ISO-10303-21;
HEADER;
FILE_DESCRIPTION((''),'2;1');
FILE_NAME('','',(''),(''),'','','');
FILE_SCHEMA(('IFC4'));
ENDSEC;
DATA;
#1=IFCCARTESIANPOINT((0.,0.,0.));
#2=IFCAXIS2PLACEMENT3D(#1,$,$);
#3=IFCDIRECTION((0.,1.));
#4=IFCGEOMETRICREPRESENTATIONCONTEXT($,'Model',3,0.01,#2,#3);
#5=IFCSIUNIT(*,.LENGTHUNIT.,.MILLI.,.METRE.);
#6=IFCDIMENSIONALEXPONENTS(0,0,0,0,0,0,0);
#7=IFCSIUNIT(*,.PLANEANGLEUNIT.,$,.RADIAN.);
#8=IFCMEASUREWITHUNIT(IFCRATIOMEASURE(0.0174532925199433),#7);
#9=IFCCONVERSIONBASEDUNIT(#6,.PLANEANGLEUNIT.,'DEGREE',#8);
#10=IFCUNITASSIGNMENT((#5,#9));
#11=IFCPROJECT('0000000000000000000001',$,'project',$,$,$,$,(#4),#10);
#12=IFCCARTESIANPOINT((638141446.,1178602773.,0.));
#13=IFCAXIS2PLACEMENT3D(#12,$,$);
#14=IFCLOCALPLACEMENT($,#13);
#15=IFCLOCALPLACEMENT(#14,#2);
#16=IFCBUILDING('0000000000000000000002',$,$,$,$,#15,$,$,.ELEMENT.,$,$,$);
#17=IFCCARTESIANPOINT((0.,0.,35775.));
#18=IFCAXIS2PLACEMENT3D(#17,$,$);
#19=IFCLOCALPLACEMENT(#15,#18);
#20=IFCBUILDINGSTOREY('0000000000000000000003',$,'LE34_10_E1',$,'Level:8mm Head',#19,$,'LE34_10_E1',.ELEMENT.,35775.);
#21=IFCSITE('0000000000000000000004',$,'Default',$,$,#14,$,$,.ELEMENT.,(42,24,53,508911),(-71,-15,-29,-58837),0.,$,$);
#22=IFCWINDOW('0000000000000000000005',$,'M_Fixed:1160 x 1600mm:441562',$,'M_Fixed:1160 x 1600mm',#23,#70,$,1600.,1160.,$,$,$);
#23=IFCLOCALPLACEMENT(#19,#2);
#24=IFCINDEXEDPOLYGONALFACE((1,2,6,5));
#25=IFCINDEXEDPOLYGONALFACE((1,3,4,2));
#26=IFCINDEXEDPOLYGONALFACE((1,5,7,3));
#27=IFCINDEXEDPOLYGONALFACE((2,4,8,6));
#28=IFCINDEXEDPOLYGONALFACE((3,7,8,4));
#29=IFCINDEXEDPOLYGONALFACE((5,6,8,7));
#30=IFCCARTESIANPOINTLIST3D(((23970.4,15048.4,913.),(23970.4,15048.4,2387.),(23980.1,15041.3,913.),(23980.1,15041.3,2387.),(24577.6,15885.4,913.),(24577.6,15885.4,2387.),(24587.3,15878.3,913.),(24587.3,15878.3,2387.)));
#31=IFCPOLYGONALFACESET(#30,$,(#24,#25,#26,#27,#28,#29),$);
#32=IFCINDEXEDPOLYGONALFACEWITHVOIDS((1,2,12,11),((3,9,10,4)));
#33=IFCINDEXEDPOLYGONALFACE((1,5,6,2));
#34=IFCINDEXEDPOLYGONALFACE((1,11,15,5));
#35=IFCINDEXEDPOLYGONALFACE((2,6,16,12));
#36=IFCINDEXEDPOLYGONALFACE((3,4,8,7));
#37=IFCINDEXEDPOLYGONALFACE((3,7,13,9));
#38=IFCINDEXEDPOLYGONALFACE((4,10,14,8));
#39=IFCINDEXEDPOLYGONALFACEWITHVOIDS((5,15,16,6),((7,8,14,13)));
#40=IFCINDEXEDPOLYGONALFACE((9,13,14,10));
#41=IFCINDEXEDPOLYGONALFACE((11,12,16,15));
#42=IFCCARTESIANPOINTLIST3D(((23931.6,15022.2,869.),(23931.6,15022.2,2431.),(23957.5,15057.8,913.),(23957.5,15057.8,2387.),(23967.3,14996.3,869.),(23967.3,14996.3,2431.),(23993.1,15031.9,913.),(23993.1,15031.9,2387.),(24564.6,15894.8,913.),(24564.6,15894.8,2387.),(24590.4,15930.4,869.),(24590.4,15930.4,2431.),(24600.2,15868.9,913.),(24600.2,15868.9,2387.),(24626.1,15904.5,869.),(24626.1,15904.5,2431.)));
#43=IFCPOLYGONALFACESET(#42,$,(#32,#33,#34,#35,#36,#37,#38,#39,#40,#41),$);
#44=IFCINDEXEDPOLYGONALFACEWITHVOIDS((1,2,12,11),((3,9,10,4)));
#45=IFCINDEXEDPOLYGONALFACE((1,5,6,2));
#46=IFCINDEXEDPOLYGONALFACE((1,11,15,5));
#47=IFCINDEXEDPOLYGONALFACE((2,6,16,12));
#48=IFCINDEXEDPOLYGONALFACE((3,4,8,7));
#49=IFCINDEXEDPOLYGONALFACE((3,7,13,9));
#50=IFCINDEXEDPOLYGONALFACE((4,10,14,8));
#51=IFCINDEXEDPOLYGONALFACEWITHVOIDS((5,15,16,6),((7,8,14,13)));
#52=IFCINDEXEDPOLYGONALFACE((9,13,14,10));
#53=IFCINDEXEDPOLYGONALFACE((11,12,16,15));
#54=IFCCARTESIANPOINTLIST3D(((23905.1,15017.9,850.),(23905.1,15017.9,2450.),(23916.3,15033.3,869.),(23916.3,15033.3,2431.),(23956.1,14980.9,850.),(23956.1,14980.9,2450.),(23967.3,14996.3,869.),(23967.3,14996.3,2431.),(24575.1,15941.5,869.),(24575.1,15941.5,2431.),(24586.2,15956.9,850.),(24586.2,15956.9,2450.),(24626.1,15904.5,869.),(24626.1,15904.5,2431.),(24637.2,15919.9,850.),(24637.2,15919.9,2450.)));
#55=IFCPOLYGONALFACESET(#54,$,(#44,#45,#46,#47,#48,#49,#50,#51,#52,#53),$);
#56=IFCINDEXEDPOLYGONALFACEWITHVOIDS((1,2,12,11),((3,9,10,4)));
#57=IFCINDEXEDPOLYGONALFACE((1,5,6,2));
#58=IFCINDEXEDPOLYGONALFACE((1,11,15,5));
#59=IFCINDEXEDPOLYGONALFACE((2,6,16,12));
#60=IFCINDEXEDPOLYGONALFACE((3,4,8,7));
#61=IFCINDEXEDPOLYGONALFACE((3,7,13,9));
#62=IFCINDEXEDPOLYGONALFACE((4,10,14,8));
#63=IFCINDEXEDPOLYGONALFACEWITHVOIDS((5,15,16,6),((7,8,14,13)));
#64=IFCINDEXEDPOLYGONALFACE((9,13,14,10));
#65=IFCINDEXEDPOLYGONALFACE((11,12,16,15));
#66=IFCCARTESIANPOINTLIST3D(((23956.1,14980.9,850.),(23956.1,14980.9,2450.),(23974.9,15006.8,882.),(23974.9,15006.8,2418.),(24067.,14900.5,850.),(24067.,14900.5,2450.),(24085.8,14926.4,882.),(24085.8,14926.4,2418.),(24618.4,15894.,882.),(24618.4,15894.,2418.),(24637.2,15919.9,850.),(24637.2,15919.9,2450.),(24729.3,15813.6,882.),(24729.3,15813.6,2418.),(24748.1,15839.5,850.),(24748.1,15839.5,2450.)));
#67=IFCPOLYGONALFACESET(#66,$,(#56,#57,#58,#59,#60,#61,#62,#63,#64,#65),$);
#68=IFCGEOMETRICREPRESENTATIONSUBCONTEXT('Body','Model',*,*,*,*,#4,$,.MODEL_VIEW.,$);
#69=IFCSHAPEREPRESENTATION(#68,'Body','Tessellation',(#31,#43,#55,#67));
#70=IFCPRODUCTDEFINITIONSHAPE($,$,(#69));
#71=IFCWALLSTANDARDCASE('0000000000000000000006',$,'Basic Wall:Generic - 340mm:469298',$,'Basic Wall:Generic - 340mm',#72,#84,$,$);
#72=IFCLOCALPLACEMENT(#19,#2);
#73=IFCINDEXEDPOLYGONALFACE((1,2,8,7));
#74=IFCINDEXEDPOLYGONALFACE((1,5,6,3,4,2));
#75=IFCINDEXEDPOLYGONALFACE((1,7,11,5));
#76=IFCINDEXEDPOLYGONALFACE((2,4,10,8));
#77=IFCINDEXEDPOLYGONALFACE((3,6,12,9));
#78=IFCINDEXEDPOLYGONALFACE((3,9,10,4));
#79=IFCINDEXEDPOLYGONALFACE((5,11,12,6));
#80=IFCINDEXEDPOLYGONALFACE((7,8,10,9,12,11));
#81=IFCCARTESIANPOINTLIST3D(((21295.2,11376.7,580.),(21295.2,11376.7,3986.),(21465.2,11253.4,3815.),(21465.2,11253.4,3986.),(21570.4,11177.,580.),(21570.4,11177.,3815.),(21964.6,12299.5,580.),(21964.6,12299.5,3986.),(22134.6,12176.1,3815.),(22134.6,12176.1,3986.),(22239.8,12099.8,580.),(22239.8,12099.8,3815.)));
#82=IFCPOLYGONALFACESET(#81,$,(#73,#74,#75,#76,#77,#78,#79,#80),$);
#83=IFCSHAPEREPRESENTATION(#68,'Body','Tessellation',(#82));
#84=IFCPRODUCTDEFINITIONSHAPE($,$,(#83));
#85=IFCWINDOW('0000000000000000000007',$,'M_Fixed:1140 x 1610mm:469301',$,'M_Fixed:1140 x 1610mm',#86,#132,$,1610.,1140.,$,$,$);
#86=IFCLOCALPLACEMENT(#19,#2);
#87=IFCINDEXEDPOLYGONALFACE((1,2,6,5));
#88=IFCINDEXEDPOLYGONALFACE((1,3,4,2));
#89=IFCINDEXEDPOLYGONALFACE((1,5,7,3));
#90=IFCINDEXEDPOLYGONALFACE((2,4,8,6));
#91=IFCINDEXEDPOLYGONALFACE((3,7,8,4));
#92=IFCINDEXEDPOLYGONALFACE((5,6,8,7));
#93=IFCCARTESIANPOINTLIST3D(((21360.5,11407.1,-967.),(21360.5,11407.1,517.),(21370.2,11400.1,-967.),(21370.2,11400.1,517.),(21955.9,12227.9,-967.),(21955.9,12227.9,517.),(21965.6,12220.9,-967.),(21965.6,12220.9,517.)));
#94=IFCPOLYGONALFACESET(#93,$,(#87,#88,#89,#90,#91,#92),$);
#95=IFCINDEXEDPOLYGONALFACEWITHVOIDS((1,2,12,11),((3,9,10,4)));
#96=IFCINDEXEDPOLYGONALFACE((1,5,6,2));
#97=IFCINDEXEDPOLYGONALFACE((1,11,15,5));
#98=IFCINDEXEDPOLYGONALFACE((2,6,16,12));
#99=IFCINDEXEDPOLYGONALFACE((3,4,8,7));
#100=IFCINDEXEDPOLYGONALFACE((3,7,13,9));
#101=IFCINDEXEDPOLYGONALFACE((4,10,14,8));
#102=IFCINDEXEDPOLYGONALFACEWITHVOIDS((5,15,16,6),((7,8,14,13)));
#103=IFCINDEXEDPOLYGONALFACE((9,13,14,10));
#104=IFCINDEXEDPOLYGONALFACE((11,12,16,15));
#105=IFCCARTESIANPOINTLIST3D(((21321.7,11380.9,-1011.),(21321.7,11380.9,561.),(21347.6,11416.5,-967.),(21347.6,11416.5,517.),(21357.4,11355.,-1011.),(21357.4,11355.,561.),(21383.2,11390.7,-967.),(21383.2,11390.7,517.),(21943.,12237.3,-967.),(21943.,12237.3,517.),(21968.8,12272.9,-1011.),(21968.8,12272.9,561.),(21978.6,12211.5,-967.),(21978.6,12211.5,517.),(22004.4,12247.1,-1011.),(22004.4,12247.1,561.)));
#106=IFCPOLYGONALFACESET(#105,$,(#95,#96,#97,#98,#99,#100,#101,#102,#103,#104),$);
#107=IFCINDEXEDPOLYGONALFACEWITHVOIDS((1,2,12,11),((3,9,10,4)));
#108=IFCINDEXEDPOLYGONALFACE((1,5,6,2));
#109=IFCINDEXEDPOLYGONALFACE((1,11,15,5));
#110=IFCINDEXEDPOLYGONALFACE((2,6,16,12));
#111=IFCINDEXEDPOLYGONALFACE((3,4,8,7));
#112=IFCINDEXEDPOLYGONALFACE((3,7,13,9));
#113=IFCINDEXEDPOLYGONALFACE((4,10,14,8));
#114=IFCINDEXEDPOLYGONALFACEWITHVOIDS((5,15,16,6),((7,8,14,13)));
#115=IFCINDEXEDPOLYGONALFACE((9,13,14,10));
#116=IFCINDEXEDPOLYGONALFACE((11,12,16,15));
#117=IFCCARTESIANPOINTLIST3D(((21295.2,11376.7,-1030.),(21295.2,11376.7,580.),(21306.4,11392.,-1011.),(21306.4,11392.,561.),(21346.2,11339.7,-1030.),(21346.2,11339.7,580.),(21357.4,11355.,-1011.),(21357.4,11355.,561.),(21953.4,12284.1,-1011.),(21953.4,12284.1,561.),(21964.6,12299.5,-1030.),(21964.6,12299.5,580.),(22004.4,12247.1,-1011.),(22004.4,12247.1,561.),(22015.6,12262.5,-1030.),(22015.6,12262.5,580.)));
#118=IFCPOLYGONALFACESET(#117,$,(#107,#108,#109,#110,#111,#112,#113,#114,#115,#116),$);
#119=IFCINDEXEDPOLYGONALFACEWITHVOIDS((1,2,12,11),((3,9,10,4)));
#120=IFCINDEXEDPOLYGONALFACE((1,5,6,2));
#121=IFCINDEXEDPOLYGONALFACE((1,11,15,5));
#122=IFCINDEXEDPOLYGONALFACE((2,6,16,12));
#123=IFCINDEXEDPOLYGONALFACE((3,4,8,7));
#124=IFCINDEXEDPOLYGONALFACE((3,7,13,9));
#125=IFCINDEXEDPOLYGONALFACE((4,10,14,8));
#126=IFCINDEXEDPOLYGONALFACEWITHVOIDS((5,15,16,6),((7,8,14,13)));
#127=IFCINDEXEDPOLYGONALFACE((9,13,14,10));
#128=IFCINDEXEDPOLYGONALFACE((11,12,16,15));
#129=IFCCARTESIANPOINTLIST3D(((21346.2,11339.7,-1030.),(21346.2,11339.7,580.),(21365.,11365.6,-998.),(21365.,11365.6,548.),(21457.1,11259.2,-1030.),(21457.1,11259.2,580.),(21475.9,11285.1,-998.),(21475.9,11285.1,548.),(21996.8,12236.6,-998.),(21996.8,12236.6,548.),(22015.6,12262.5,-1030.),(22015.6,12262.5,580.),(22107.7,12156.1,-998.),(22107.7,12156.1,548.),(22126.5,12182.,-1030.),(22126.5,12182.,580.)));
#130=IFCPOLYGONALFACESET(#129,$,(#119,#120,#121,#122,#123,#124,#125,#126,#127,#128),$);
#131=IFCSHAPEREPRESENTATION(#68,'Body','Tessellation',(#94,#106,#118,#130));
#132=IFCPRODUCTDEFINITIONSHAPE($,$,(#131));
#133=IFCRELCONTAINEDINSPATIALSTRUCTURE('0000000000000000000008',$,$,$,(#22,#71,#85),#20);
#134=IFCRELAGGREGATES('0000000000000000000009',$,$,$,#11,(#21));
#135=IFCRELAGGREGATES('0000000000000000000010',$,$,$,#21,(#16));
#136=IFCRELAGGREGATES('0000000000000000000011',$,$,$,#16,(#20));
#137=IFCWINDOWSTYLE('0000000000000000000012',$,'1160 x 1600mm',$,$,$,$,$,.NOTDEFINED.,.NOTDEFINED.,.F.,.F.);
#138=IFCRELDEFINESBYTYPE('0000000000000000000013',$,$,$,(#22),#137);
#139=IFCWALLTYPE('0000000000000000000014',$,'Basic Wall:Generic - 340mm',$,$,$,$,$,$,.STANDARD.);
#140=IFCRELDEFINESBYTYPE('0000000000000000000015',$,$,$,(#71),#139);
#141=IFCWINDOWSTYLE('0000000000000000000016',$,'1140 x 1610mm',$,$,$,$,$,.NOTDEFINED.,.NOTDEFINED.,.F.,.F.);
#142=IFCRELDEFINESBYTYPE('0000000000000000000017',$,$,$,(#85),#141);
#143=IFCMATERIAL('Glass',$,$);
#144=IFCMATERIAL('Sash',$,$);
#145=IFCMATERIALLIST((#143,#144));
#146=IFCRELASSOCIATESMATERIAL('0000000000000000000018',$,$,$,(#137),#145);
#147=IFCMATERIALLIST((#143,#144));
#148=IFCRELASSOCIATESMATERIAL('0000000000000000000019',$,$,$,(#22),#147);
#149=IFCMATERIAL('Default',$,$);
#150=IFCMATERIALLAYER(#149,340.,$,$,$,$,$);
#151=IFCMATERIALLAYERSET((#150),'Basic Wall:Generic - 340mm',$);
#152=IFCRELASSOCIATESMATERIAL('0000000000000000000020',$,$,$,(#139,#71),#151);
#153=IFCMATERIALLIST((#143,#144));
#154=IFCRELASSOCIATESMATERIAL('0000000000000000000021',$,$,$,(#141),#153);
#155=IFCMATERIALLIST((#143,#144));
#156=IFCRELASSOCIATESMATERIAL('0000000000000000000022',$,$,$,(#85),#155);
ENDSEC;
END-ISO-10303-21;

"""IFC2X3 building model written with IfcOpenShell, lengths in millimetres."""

from ifc_helpers import new_model, entity, si_unit, converted_unit, direction, frame, frame_2d, origin, place, context, subcontext, project, spatial, polyline, rectangle, outline, extrude, clip, bounded_halfspace, source, transform, mapped, material, material_list, layer, layer_set, layer_usage, type_object, type_shapes, element, fill, save


model = new_model("IFC2X3")

# Units and contexts
model_context = context("Model", 3, precision=0.01, world=origin(), true_north=direction((0.0, 1.0)))
body_context = subcontext(model_context, "Body", "Model", "MODEL_VIEW")
ifc_project = project(units=[si_unit("LENGTHUNIT", "METRE", prefix="MILLI"), converted_unit("PLANEANGLEUNIT", "DEGREE", entity("IfcRatioMeasure", 0.0174532925199433), si_unit("PLANEANGLEUNIT", "RADIAN"), dimensions=[0, 0, 0, 0, 0, 0, 0])], contexts=[model_context])

# Site, building, storey
site_placement = place(None, frame((638141446.0, 1178602773.0, 0.0)))
site = spatial("IfcSite", under=ifc_project, at=site_placement, Name="Default", CompositionType="ELEMENT", RefLatitude=(42, 24, 53, 508911), RefLongitude=(-71, -15, -29, -58837), RefElevation=0.0)
building_placement = place(site_placement, origin())
building = spatial("IfcBuilding", under=site, at=building_placement, CompositionType="ELEMENT")
storey_placement = place(building_placement, frame((0.0, 0.0, 35775.0)))
storey = spatial("IfcBuildingStorey", under=building, at=storey_placement, Name="LE34_10_E1", ObjectType="Level:8mm Head", LongName="LE34_10_E1", CompositionType="ELEMENT", Elevation=35775.0)

# Shared definitions
ifc_material_1 = material(Name="Default")

# Window
ifc_material_2 = material(Name="Glass")
ifc_material_3 = material(Name="Sash")
ifc_material_list_1 = material_list([ifc_material_2, ifc_material_3])
ifc_material_list_2 = material_list([ifc_material_2, ifc_material_3])
window_style_1 = type_object("IfcWindowStyle", Name="1160 x 1600mm", ConstructionType="NOTDEFINED", OperationType="NOTDEFINED", ParameterTakesPrecedence=False, Sizeable=False, material=ifc_material_list_2)
shared_shape_1 = source(origin(), body_context, "Body", "SweptSolid", [
    extrude(rectangle(XDim=12.0, YDim=1034.0, at=frame_2d((0.0, 0.0), x_axis=(1.0, 0.0))), frame((580.0, 269.0, 63.0), z_axis=(0.0, 0.0, 1.0), x_axis=(0.0, -1.0, 0.0)), (0.0, 0.0, 1.0), 1474.0),
    extrude(outline(polyline([(-561.0, -781.0), (561.0, -781.0), (561.0, 781.0), (-561.0, 781.0), (-561.0, -781.0)]), holes=[polyline([(-517.0, -737.0), (-517.0, 737.0), (517.0, 737.0), (517.0, -737.0), (-517.0, -737.0)])]), frame((580.0, 247.0, 800.0), z_axis=(0.0, 1.0, 0.0), x_axis=(1.0, 0.0, 0.0)), (0.0, 0.0, 1.0), 44.0),
    extrude(outline(polyline([(-580.0, -800.0), (580.0, -800.0), (580.0, 800.0), (-580.0, 800.0), (-580.0, -800.0)]), holes=[polyline([(-561.0, -781.0), (-561.0, 781.0), (561.0, 781.0), (561.0, -781.0), (-561.0, -781.0)])]), frame((580.0, 247.0, 800.0), z_axis=(0.0, 1.0, 0.0), x_axis=(1.0, 0.0, 0.0)), (0.0, 0.0, 1.0), 63.0),
    extrude(outline(polyline([(-580.0, -800.0), (580.0, -800.0), (580.0, 800.0), (-580.0, 800.0), (-580.0, -800.0)]), holes=[polyline([(-548.0, -768.0), (-548.0, 768.0), (548.0, 768.0), (548.0, -768.0), (-548.0, -768.0)])]), frame((580.0, 110.0, 800.0), z_axis=(0.0, 1.0, 0.0), x_axis=(1.0, 0.0, 0.0)), (0.0, 0.0, 1.0), 137.0),
])
type_shapes(window_style_1, [shared_shape_1])
window_1_placement = place(storey_placement, frame((24156.0, 14835.9, 850.0), z_axis=(0.0, 0.0, 1.0), x_axis=(0.587164, 0.809468, 0.0)))
element("IfcWindow", 1, at=window_1_placement, inside=storey, type_object=window_style_1, material=ifc_material_list_1, Name="M_Fixed:1160 x 1600mm:441562", ObjectType="M_Fixed:1160 x 1600mm", OverallHeight=1600.0, OverallWidth=1160.0, context=body_context, shape_type="MappedRepresentation", body=[
    mapped(shared_shape_1, transform((0.0, 0.0, 0.0), scale=1.0)),
])

# Wall, opening, window
ifc_layer_1 = layer(ifc_material_1, 340.0)
ifc_layer_set_1 = layer_set([ifc_layer_1], Name="Basic Wall:Generic - 340mm")
ifc_layer_usage_1 = layer_usage(ifc_layer_set_1, "AXIS2", "NEGATIVE", 170.0)
wall_type_1 = type_object("IfcWallType", Name="Basic Wall:Generic - 340mm", PredefinedType="STANDARD", material=ifc_layer_set_1)
wall_1_placement = place(storey_placement, frame((21432.8, 11276.8, 580.0), z_axis=(0.0, 0.0, 1.0), x_axis=(0.587164, 0.809468, 0.0)))
wall_1 = element("IfcWallStandardCase", 2, at=wall_1_placement, inside=storey, type_object=wall_type_1, material=ifc_layer_usage_1, Name="Basic Wall:Generic - 340mm:469298", ObjectType="Basic Wall:Generic - 340mm", context=body_context, shape_type="Clipping", body=[
    clip(clip(extrude(rectangle(XDim=1140.0, YDim=340.0, at=frame_2d((570.0, 0.0), x_axis=(-1.0, 0.0))), origin(), (0.0, 0.0, 1.0), 3406.0), bounded_halfspace(frame((1140.0, -40.0, 3235.0), z_axis=(0.0, 0.0, 1.0), x_axis=(-1.0, 0.0, 0.0)), False, frame((1140.0, -40.0, 3235.0), z_axis=(0.0, 0.0, 1.0), x_axis=(-1.0, 0.0, 0.0)), polyline([(0.0, 0.0), (1140.0, 0.0), (1140.0, 130.0), (0.0, 130.0), (0.0, 0.0)]))), bounded_halfspace(frame((0.0, -40.0, 3235.0), z_axis=(0.0, 1.0, 0.0), x_axis=(-1.0, 0.0, 0.0)), True, frame((0.0, -40.0, 3235.0), z_axis=(0.0, 1.0, 0.0), x_axis=(-1.0, 0.0, 0.0)), polyline([(0.0, 0.0), (0.0, 100.0), (0.0, 171.0), (-1140.0, 171.0), (-1140.0, 0.0), (0.0, 0.0)]))),
])
opening_1_placement = place(wall_1_placement, frame((0.0, -170.0, -1610.0)))
opening_1 = element("IfcOpeningElement", 3, at=opening_1_placement, cuts=wall_1, ObjectType="Opening", context=body_context, shape_type="SweptSolid", body=[
    extrude(rectangle(XDim=1610.0, YDim=1140.0, at=frame_2d((805.0, 570.0), x_axis=(1.0, 0.0))), frame((0.0, 0.0, 0.0), z_axis=(0.0, 1.0, 0.0), x_axis=(0.0, 0.0, 1.0)), (0.0, 0.0, 1.0), 340.0),
])
ifc_material_list_3 = material_list([ifc_material_2, ifc_material_3])
ifc_material_list_4 = material_list([ifc_material_2, ifc_material_3])
window_style_2 = type_object("IfcWindowStyle", Name="1140 x 1610mm", ConstructionType="NOTDEFINED", OperationType="NOTDEFINED", ParameterTakesPrecedence=False, Sizeable=False, material=ifc_material_list_4)
shared_shape_2 = source(origin(), body_context, "Body", "SweptSolid", [
    extrude(rectangle(XDim=12.0, YDim=1014.0, at=frame_2d((0.0, 0.0), x_axis=(1.0, 0.0))), frame((570.0, 299.0, 63.0), z_axis=(0.0, 0.0, 1.0), x_axis=(0.0, -1.0, 0.0)), (0.0, 0.0, 1.0), 1484.0),
    extrude(outline(polyline([(-551.0, -786.0), (551.0, -786.0), (551.0, 786.0), (-551.0, 786.0), (-551.0, -786.0)]), holes=[polyline([(-507.0, -742.0), (-507.0, 742.0), (507.0, 742.0), (507.0, -742.0), (-507.0, -742.0)])]), frame((570.0, 277.0, 805.0), z_axis=(0.0, 1.0, 0.0), x_axis=(1.0, 0.0, 0.0)), (0.0, 0.0, 1.0), 44.0),
    extrude(outline(polyline([(-570.0, -805.0), (570.0, -805.0), (570.0, 805.0), (-570.0, 805.0), (-570.0, -805.0)]), holes=[polyline([(-551.0, -786.0), (-551.0, 786.0), (551.0, 786.0), (551.0, -786.0), (-551.0, -786.0)])]), frame((570.0, 277.0, 805.0), z_axis=(0.0, 1.0, 0.0), x_axis=(1.0, 0.0, 0.0)), (0.0, 0.0, 1.0), 63.0),
    extrude(outline(polyline([(-570.0, -805.0), (570.0, -805.0), (570.0, 805.0), (-570.0, 805.0), (-570.0, -805.0)]), holes=[polyline([(-538.0, -773.0), (-538.0, 773.0), (538.0, 773.0), (538.0, -773.0), (-538.0, -773.0)])]), frame((570.0, 140.0, 805.0), z_axis=(0.0, 1.0, 0.0), x_axis=(1.0, 0.0, 0.0)), (0.0, 0.0, 1.0), 137.0),
])
type_shapes(window_style_2, [shared_shape_2])
window_2_placement = place(opening_1_placement, origin())
window_2 = element("IfcWindow", 4, at=window_2_placement, inside=storey, type_object=window_style_2, material=ifc_material_list_3, Name="M_Fixed:1140 x 1610mm:469301", ObjectType="M_Fixed:1140 x 1610mm", OverallHeight=1610.0, OverallWidth=1140.0, context=body_context, shape_type="MappedRepresentation", body=[
    mapped(shared_shape_2, transform((0.0, 0.0, 0.0), scale=1.0)),
])
fill(opening_1, window_2)

save(model, "model.ifc")
